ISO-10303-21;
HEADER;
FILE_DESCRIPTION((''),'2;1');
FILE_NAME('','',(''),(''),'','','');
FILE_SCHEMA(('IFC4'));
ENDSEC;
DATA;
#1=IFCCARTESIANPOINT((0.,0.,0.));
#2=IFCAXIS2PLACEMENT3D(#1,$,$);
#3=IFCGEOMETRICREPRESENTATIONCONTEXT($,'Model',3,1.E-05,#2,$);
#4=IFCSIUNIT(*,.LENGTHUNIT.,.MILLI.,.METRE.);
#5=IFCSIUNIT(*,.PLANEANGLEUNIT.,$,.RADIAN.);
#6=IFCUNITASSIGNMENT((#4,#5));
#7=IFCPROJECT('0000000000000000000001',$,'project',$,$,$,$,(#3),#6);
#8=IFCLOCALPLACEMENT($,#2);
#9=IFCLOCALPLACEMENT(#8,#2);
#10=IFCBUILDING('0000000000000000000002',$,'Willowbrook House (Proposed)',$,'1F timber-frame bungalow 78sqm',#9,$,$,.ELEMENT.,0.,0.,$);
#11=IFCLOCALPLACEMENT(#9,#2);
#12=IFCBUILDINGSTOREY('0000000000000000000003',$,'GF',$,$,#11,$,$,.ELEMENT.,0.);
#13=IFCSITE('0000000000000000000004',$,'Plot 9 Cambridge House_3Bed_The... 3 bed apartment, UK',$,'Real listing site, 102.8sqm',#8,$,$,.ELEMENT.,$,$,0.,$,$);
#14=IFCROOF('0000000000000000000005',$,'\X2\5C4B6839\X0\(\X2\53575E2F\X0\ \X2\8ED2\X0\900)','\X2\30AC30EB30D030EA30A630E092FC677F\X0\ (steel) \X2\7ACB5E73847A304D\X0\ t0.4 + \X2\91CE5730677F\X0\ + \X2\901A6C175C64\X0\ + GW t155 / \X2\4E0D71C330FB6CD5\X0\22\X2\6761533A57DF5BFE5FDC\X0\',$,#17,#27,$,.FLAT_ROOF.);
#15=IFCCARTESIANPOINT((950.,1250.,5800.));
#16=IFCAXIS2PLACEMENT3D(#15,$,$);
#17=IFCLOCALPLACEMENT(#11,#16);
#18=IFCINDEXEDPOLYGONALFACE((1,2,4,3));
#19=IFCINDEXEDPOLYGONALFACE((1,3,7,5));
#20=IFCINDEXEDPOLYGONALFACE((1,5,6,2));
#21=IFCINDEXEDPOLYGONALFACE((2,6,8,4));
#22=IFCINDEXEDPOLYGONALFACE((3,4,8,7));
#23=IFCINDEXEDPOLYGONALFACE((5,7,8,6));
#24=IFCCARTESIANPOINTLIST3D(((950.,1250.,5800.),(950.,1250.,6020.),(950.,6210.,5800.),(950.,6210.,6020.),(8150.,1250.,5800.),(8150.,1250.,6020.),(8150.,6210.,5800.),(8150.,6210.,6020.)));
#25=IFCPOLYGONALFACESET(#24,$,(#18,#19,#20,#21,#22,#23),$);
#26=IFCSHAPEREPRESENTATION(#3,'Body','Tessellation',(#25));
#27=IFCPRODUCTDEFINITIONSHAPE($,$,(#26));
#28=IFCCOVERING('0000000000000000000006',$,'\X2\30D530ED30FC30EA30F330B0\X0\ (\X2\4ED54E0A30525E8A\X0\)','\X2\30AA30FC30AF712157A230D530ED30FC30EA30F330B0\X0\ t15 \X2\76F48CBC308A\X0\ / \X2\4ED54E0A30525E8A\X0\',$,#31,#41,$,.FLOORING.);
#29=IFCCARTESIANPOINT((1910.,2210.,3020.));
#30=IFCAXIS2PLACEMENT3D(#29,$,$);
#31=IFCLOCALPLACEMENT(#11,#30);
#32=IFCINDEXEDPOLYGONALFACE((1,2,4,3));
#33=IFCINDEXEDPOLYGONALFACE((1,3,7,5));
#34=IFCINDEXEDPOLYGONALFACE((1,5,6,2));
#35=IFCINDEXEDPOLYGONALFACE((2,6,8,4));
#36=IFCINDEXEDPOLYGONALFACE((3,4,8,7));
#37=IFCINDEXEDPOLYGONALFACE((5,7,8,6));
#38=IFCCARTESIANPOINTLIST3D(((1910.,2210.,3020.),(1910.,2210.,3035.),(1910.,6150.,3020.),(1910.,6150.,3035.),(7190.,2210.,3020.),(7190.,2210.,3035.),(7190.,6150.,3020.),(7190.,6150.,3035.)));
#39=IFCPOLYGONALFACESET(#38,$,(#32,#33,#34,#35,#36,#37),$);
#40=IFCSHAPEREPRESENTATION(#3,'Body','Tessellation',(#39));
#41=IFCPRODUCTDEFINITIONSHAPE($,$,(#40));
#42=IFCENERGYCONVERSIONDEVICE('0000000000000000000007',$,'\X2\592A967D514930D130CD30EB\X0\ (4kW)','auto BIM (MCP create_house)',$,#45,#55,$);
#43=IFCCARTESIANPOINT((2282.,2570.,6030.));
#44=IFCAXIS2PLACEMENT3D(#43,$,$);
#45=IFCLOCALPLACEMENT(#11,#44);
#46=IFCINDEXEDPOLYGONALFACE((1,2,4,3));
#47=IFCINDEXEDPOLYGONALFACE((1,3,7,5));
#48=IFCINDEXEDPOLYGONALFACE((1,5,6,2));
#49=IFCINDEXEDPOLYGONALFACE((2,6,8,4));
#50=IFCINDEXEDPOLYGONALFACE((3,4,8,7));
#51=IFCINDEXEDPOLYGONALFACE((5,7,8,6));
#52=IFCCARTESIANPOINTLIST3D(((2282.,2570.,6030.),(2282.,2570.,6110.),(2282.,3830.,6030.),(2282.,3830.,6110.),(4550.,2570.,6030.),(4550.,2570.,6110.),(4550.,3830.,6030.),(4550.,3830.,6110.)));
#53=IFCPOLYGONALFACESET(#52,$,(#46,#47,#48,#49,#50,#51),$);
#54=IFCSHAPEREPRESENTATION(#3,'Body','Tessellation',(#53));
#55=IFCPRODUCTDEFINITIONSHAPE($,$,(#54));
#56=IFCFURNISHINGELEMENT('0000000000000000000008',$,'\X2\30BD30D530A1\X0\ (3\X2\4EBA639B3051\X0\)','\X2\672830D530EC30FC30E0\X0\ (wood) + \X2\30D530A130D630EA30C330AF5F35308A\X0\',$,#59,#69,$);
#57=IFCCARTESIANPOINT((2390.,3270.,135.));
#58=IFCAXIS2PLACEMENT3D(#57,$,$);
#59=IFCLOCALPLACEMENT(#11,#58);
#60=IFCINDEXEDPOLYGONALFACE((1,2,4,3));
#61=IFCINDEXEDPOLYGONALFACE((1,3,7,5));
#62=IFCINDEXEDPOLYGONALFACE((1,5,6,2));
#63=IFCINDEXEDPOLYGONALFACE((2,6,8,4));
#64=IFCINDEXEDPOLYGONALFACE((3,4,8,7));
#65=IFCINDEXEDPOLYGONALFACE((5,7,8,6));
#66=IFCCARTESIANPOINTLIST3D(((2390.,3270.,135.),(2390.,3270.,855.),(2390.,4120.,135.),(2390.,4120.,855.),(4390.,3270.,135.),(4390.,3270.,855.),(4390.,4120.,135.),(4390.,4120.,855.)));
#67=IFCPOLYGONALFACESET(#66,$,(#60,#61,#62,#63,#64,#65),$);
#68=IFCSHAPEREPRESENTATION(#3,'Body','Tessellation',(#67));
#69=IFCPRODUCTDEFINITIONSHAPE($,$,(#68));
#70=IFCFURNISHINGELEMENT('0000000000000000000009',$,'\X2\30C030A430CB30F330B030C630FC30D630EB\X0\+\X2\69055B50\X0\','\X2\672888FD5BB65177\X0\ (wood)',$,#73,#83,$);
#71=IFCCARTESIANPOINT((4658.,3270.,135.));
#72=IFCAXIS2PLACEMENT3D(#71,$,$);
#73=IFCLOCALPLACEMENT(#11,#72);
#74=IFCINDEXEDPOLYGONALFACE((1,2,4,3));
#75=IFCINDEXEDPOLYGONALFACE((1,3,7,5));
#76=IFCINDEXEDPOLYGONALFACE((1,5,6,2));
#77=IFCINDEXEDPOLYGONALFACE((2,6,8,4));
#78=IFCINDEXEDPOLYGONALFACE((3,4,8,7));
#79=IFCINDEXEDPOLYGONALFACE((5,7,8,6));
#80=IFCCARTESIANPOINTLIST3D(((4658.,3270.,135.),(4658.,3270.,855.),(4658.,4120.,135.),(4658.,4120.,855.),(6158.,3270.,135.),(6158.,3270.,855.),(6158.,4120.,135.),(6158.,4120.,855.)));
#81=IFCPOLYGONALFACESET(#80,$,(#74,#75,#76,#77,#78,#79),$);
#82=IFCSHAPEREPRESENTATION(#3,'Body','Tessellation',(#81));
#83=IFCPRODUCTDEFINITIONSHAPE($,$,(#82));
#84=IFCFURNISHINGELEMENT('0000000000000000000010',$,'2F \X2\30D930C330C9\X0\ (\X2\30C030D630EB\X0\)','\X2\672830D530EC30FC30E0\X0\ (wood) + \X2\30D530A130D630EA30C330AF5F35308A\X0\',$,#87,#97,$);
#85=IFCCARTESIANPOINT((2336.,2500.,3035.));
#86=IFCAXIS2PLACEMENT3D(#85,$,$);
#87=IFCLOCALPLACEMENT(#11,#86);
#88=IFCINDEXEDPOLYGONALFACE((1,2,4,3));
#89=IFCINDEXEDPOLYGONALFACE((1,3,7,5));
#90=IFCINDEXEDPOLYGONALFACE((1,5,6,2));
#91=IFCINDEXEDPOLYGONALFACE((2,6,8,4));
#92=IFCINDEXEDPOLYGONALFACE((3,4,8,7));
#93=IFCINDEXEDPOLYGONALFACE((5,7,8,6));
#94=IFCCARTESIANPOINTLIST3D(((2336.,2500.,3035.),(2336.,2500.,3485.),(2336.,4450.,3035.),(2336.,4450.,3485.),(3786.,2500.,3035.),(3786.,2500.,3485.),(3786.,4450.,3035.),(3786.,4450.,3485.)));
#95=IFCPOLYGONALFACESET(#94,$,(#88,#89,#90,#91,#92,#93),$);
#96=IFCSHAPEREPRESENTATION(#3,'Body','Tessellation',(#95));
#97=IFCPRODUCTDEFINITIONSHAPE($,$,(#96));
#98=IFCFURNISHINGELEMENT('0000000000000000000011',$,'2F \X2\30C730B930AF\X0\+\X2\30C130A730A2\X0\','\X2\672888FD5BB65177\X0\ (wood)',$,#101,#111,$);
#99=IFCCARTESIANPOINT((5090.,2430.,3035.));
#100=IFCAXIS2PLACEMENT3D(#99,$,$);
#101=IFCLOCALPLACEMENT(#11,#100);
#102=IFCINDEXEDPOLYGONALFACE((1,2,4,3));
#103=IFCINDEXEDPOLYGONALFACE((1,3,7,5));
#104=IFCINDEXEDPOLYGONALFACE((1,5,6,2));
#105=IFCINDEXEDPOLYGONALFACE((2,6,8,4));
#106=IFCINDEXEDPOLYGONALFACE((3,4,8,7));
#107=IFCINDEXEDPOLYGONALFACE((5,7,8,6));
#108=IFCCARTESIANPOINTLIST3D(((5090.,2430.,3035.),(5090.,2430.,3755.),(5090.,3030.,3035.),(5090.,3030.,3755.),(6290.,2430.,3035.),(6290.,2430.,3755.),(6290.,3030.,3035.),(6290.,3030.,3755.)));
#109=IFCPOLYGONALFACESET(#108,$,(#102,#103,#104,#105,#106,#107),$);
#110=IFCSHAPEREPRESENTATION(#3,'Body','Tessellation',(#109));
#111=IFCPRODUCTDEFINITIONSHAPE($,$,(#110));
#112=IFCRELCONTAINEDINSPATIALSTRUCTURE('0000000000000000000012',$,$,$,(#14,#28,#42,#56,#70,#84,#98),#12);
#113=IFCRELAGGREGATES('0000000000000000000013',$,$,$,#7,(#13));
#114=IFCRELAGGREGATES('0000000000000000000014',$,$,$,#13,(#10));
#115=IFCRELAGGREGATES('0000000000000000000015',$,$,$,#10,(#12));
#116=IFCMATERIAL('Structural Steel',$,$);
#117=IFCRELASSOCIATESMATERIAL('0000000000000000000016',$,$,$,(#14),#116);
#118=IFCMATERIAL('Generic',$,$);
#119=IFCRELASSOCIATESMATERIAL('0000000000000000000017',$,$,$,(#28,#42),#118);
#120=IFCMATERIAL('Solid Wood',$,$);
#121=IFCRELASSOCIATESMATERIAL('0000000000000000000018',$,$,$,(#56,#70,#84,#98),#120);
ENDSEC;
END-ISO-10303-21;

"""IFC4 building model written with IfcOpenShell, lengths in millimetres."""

from ifc_helpers import new_model, si_unit, frame, frame_2d, origin, place, context, project, spatial, rectangle, extrude, material, element, save


model = new_model("IFC4")

# Units and contexts
model_context = context("Model", 3, precision=1e-05, world=origin())
ifc_project = project(units=[si_unit("LENGTHUNIT", "METRE", prefix="MILLI"), si_unit("PLANEANGLEUNIT", "RADIAN")], contexts=[model_context])

# Site, building, storey
site_placement = place(None, origin())
site = spatial("IfcSite", under=ifc_project, at=site_placement, Name="Plot 9 Cambridge House_3Bed_The... 3 bed apartment, UK", ObjectType="Real listing site, 102.8sqm", CompositionType="ELEMENT", RefElevation=0.0)
building_placement = place(site_placement, origin())
building = spatial("IfcBuilding", under=site, at=building_placement, Name="Willowbrook House (Proposed)", ObjectType="1F timber-frame bungalow 78sqm", CompositionType="ELEMENT", ElevationOfRefHeight=0.0, ElevationOfTerrain=0.0)
storey_placement = place(building_placement, origin())
storey = spatial("IfcBuildingStorey", under=building, at=storey_placement, Name="GF", CompositionType="ELEMENT", Elevation=0.0)

# Shared definitions
ifc_material_1 = material(Name="Solid Wood")

# Shared definitions
ifc_material_2 = material(Name="Generic")

# Roof
ifc_material_3 = material(Name="Structural Steel")
for number, where, name in (
    (1, (950.0, 1250.0, 5800.0), "屋根(南帯 軒900)"),
):
    element("IfcRoof", number, at=place(storey_placement, frame(where)), inside=storey, material=ifc_material_3, Name=name, Description="ガルバリウム鋼板 (steel) 立平葺き t0.4 + 野地板 + 通気層 + GW t155 / 不燃・法22条区域対応", PredefinedType="FLAT_ROOF", context=model_context, shape_type="SweptSolid", body=[
        extrude(rectangle(XDim=7200.0, YDim=4960.0, at=frame_2d((3600.0, 2480.0))), frame((950.0, 1250.0, 5800.0)), (0.0, 0.0, 1.0), 220.0),
    ])

# Covering
covering_placement = place(storey_placement, frame((1910.0, 2210.0, 3020.0)))
element("IfcCovering", 2, at=covering_placement, inside=storey, material=ifc_material_2, Name="フローリング (仕上げ床)", Description="オーク無垢フローリング t15 直貼り / 仕上げ床", PredefinedType="FLOORING", context=model_context, shape_type="SweptSolid", body=[
    extrude(rectangle(XDim=5280.0, YDim=3940.0, at=frame_2d((2640.0, 1970.0))), frame((1910.0, 2210.0, 3020.0)), (0.0, 0.0, 1.0), 15.0),
])

# Energy conversion device
energy_conversion_device_placement = place(storey_placement, frame((2282.0, 2570.0, 6030.0)))
element("IfcEnergyConversionDevice", 3, at=energy_conversion_device_placement, inside=storey, material=ifc_material_2, Name="太陽光パネル (4kW)", Description="auto BIM (MCP create_house)", context=model_context, shape_type="SweptSolid", body=[
    extrude(rectangle(XDim=2268.0, YDim=1260.0, at=frame_2d((1134.0, 630.0))), frame((2282.0, 2570.0, 6030.0)), (0.0, 0.0, 1.0), 80.0),
])

# Furnishing elements
furnishing_1_placement = place(storey_placement, frame((2390.0, 3270.0, 135.0)))
element("IfcFurnishingElement", 4, at=furnishing_1_placement, inside=storey, material=ifc_material_1, Name="ソファ (3人掛け)", Description="木フレーム (wood) + ファブリック張り", context=model_context, shape_type="SweptSolid", body=[
    extrude(rectangle(XDim=2000.0, YDim=850.0, at=frame_2d((1000.0, 425.0))), frame((2390.0, 3270.0, 135.0)), (0.0, 0.0, 1.0), 720.0),
])
furnishing_2_placement = place(storey_placement, frame((4658.0, 3270.0, 135.0)))
element("IfcFurnishingElement", 5, at=furnishing_2_placement, inside=storey, material=ifc_material_1, Name="ダイニングテーブル+椅子", Description="木製家具 (wood)", context=model_context, shape_type="SweptSolid", body=[
    extrude(rectangle(XDim=1500.0, YDim=850.0, at=frame_2d((750.0, 425.0))), frame((4658.0, 3270.0, 135.0)), (0.0, 0.0, 1.0), 720.0),
])
furnishing_3_placement = place(storey_placement, frame((2336.0, 2500.0, 3035.0)))
element("IfcFurnishingElement", 6, at=furnishing_3_placement, inside=storey, material=ifc_material_1, Name="2F ベッド (ダブル)", Description="木フレーム (wood) + ファブリック張り", context=model_context, shape_type="SweptSolid", body=[
    extrude(rectangle(XDim=1450.0, YDim=1950.0, at=frame_2d((725.0, 975.0))), frame((2336.0, 2500.0, 3035.0)), (0.0, 0.0, 1.0), 450.0),
])
furnishing_4_placement = place(storey_placement, frame((5090.0, 2430.0, 3035.0)))
element("IfcFurnishingElement", 7, at=furnishing_4_placement, inside=storey, material=ifc_material_1, Name="2F デスク+チェア", Description="木製家具 (wood)", context=model_context, shape_type="SweptSolid", body=[
    extrude(rectangle(XDim=1200.0, YDim=600.0, at=frame_2d((600.0, 300.0))), frame((5090.0, 2430.0, 3035.0)), (0.0, 0.0, 1.0), 720.0),
])

save(model, "model.ifc")
